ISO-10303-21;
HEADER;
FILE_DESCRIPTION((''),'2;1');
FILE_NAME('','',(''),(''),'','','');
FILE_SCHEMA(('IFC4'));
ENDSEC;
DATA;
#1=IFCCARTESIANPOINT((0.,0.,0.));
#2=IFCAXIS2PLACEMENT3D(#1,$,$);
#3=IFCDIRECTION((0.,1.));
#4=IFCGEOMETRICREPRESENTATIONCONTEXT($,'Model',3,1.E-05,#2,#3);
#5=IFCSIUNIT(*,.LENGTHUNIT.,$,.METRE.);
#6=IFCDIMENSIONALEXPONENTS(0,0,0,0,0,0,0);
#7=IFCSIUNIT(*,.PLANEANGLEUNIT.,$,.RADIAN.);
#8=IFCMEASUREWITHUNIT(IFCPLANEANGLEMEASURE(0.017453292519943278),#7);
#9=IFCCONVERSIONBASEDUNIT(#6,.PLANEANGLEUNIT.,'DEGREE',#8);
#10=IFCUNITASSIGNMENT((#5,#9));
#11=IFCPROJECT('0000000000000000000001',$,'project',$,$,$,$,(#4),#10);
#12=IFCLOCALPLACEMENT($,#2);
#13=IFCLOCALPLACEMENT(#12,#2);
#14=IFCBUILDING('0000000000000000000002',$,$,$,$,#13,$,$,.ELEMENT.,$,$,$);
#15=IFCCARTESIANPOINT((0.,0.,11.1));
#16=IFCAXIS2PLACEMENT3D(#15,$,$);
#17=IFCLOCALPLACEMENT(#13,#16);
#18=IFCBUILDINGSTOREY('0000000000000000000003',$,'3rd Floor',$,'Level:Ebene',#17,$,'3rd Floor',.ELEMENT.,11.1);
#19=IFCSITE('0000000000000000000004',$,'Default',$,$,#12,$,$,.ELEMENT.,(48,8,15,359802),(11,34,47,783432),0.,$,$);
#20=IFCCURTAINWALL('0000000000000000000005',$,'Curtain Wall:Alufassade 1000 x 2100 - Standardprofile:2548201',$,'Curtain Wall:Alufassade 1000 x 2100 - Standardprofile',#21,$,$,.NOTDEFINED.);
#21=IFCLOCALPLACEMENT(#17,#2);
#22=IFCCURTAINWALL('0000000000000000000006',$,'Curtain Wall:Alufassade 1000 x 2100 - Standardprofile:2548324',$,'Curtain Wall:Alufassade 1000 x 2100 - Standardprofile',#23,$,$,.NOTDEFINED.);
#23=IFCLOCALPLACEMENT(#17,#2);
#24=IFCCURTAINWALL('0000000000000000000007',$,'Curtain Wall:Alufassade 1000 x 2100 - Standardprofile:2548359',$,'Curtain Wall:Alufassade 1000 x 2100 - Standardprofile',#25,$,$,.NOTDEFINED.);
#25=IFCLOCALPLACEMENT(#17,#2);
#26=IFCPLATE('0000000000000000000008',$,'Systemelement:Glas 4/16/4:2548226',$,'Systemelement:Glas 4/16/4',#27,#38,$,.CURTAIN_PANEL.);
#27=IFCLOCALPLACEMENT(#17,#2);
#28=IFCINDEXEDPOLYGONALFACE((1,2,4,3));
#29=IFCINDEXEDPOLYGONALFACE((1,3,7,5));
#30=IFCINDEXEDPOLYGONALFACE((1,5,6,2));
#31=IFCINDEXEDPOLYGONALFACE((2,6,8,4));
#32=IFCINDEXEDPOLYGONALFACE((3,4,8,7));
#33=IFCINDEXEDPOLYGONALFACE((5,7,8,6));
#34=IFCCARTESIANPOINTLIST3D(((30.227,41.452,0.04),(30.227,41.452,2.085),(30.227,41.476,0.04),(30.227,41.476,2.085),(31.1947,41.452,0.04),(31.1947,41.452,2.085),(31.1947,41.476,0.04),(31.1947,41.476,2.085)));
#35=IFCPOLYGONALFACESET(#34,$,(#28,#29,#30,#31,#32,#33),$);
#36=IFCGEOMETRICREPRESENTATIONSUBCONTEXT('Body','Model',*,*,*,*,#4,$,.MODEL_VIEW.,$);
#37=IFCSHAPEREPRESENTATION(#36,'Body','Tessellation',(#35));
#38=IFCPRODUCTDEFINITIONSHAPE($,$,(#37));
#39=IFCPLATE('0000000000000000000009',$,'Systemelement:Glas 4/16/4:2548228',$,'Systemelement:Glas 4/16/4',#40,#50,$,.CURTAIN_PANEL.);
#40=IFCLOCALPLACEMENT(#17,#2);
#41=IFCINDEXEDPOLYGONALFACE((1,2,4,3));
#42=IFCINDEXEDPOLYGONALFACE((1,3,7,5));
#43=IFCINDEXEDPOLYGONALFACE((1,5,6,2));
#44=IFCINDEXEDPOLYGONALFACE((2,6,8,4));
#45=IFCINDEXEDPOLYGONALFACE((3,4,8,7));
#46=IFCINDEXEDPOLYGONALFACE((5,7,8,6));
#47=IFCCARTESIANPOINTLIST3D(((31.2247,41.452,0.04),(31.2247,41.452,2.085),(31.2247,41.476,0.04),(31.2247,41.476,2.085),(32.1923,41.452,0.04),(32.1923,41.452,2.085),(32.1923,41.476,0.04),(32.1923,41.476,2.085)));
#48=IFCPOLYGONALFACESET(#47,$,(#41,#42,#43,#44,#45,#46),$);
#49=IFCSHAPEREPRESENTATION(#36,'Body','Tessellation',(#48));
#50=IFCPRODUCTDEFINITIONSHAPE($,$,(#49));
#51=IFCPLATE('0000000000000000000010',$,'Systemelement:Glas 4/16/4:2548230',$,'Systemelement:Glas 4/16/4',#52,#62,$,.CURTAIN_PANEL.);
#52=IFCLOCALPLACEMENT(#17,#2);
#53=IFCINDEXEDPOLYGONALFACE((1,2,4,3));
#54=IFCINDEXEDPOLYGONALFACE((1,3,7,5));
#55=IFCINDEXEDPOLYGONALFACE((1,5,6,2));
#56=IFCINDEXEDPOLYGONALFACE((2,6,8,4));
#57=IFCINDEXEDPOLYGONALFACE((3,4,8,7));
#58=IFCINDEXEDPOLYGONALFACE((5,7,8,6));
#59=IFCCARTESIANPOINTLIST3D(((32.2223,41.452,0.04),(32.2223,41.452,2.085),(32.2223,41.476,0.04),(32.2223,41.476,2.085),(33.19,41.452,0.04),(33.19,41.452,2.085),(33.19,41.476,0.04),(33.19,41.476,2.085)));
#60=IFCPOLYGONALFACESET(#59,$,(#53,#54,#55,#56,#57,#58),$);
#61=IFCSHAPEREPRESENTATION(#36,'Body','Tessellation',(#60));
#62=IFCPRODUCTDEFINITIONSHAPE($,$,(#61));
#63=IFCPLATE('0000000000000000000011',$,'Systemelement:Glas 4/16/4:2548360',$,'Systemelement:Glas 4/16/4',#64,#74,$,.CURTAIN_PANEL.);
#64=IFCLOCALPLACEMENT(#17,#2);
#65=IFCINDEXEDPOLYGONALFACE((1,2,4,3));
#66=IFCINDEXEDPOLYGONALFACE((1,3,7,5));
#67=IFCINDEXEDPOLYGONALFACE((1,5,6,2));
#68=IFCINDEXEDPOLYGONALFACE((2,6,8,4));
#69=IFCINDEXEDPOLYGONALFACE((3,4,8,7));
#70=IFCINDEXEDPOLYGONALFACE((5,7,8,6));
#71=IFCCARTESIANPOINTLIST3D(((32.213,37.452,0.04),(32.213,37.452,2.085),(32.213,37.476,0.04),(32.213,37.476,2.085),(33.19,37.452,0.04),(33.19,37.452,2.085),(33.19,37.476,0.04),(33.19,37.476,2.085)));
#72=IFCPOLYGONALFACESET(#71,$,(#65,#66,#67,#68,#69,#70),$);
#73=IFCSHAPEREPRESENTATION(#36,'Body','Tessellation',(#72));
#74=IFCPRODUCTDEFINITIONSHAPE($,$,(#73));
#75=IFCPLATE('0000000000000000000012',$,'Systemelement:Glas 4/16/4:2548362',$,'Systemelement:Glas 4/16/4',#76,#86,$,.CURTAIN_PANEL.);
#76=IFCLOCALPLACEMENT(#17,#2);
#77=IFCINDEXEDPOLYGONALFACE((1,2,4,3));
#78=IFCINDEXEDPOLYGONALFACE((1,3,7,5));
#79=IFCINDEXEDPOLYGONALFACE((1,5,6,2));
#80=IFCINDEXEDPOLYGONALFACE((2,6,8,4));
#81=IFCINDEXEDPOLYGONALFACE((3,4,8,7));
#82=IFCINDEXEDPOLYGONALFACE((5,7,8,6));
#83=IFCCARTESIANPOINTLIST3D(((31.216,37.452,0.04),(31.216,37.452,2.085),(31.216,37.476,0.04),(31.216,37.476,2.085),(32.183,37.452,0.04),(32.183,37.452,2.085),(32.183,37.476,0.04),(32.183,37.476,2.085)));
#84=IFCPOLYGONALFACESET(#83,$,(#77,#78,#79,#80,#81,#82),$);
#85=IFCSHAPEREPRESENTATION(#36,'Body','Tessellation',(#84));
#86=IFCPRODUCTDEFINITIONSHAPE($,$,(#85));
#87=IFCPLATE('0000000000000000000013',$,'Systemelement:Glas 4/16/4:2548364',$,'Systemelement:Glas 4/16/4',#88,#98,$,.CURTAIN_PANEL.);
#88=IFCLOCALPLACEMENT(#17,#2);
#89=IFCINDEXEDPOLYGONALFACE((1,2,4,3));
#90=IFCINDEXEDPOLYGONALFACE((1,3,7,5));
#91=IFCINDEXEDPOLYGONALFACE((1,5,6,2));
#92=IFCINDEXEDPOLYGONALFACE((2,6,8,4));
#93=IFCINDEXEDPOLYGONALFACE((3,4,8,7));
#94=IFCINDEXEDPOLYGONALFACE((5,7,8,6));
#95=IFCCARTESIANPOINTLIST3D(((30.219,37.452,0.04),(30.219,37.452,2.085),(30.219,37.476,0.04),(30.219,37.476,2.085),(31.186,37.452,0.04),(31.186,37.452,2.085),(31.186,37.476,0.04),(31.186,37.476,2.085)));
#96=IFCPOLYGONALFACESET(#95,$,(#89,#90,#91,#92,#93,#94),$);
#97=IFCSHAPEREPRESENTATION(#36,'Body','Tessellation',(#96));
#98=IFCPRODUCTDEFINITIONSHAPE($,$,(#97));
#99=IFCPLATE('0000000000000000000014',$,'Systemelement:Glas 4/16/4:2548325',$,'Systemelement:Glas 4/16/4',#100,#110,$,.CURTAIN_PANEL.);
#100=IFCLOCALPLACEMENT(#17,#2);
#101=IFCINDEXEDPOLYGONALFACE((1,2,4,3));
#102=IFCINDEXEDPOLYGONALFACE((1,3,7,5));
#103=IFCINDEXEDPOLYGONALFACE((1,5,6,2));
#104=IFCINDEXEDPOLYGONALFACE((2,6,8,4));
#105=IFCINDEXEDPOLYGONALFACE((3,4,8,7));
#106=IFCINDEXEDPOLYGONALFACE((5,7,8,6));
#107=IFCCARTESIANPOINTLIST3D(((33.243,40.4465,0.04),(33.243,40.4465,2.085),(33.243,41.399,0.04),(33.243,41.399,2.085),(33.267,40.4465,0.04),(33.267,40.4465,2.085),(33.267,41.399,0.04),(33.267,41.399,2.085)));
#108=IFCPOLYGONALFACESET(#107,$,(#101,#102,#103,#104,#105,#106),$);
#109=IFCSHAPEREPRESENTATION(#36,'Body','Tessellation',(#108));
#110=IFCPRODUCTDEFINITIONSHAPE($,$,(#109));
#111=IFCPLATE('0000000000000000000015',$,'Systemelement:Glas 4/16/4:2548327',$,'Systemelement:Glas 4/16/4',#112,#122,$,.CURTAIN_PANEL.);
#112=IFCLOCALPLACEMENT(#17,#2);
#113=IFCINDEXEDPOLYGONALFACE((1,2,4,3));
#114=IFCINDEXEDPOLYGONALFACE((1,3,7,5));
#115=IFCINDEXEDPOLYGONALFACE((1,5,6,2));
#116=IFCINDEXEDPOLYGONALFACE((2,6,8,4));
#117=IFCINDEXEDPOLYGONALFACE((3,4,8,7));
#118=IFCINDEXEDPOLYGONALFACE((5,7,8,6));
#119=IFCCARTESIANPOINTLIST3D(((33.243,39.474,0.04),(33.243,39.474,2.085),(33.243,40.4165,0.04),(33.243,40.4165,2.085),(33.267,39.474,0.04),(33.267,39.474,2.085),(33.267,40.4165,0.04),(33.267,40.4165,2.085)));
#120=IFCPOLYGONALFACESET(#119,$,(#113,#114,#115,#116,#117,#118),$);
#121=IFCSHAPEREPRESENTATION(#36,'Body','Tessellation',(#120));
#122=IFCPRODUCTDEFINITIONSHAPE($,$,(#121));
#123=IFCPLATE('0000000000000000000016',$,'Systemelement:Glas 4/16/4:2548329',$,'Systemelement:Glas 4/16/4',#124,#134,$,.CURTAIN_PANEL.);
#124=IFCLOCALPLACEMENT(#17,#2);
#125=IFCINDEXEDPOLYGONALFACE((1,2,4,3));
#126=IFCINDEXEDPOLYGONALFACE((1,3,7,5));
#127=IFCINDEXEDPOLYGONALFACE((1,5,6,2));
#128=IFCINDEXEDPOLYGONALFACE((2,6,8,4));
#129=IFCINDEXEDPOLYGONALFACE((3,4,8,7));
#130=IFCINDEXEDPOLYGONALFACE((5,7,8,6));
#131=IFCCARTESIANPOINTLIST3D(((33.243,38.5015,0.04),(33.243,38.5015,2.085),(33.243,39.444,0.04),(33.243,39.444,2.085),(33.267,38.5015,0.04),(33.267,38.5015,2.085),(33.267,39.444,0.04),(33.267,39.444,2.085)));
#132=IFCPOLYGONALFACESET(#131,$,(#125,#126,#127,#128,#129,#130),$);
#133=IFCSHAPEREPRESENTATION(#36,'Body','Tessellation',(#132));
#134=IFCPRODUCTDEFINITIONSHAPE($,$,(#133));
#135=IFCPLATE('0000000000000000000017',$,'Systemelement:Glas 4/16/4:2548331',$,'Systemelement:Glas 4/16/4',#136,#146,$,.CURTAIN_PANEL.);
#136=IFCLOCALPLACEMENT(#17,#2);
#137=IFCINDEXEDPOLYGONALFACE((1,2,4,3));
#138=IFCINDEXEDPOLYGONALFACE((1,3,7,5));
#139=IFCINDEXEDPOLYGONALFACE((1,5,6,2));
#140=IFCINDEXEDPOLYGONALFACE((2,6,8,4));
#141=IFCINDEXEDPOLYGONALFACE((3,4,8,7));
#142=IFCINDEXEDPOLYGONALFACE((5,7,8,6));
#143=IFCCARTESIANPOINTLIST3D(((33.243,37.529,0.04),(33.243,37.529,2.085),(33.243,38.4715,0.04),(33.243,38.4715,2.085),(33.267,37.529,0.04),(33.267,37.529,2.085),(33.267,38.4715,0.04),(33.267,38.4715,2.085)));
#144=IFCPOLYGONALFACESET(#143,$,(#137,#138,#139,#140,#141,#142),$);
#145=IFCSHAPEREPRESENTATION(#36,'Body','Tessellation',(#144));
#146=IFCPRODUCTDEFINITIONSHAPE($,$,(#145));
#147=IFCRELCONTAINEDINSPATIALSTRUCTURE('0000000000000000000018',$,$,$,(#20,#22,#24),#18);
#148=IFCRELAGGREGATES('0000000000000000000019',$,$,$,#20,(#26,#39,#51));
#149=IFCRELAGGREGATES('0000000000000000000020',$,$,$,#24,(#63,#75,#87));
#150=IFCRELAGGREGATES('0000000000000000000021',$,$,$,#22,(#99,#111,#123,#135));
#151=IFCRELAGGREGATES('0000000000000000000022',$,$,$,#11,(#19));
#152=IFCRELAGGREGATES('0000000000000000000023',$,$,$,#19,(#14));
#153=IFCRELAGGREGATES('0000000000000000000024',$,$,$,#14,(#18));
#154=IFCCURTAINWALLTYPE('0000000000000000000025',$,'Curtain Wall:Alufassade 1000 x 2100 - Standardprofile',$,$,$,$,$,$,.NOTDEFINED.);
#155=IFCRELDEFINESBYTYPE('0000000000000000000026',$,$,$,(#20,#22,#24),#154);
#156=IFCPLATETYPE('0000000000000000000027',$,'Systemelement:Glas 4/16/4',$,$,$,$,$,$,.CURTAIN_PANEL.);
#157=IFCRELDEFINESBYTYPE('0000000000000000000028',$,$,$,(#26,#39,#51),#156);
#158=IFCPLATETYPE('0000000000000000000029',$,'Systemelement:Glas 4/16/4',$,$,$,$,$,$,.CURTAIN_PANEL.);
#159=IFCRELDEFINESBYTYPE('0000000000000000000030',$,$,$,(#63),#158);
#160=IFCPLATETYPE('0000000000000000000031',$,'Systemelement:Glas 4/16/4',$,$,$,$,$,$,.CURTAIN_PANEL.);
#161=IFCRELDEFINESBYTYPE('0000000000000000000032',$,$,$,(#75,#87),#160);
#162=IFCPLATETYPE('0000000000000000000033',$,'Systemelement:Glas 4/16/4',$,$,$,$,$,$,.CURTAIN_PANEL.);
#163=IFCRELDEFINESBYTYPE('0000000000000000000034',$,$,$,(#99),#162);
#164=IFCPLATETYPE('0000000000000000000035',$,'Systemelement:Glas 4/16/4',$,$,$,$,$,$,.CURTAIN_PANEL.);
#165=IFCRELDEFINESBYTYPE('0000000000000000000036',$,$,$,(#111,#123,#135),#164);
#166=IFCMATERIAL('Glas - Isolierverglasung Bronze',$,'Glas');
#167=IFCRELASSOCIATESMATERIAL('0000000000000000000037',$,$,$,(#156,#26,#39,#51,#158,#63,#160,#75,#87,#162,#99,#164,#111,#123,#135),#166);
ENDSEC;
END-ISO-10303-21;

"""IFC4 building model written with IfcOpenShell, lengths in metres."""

from ifc_helpers import new_model, entity, si_unit, converted_unit, direction, frame, origin, place, context, subcontext, project, spatial, indexed_curve, outline, extrude, source, transform, mapped, material, type_object, type_shapes, element, aggregate, save


model = new_model("IFC4")

# Units and contexts
model_context = context("Model", 3, precision=1e-05, world=origin(), true_north=direction((0.0, 1.0)))
body_context = subcontext(model_context, "Body", "Model", "MODEL_VIEW")
ifc_project = project(units=[si_unit("LENGTHUNIT", "METRE"), converted_unit("PLANEANGLEUNIT", "DEGREE", entity("IfcPlaneAngleMeasure", 0.017453292519943278), si_unit("PLANEANGLEUNIT", "RADIAN"), dimensions=[0, 0, 0, 0, 0, 0, 0])], contexts=[model_context])

# Site, building, storey
site_placement = place(None, origin())
site = spatial("IfcSite", under=ifc_project, at=site_placement, Name="Default", CompositionType="ELEMENT", RefLatitude=(48, 8, 15, 359802), RefLongitude=(11, 34, 47, 783432), RefElevation=0.0)
building_placement = place(site_placement, origin())
building = spatial("IfcBuilding", under=site, at=building_placement, CompositionType="ELEMENT")
storey_placement = place(building_placement, frame((0.0, 0.0, 11.1)))
storey = spatial("IfcBuildingStorey", under=building, at=storey_placement, Name="3rd Floor", ObjectType="Level:Ebene", LongName="3rd Floor", CompositionType="ELEMENT", Elevation=11.1)

# Curtain walls
curtain_wall_type = type_object("IfcCurtainWallType", Name="Curtain Wall:Alufassade 1000 x 2100 - Standardprofile", PredefinedType="NOTDEFINED")
curtain_wall_1_placement = place(storey_placement, frame((0.0, 0.0, -11.1)))
curtain_wall_1 = element("IfcCurtainWall", 1, at=curtain_wall_1_placement, inside=storey, type_object=curtain_wall_type, Name="Curtain Wall:Alufassade 1000 x 2100 - Standardprofile:2548201", ObjectType="Curtain Wall:Alufassade 1000 x 2100 - Standardprofile", PredefinedType="NOTDEFINED")
curtain_wall_2_placement = place(storey_placement, frame((0.0, 0.0, -11.1)))
curtain_wall_2 = element("IfcCurtainWall", 2, at=curtain_wall_2_placement, inside=storey, type_object=curtain_wall_type, Name="Curtain Wall:Alufassade 1000 x 2100 - Standardprofile:2548324", ObjectType="Curtain Wall:Alufassade 1000 x 2100 - Standardprofile", PredefinedType="NOTDEFINED")

# Curtain wall
curtain_wall_3_placement = place(storey_placement, frame((0.0, 0.0, -11.1)))
curtain_wall_3 = element("IfcCurtainWall", 3, at=curtain_wall_3_placement, inside=storey, type_object=curtain_wall_type, Name="Curtain Wall:Alufassade 1000 x 2100 - Standardprofile:2548359", ObjectType="Curtain Wall:Alufassade 1000 x 2100 - Standardprofile", PredefinedType="NOTDEFINED")

# Plates
ifc_material_1 = material(Name="Glas - Isolierverglasung Bronze", Category="Glas")
plate_type_1 = type_object("IfcPlateType", Name="Systemelement:Glas 4/16/4", PredefinedType="CURTAIN_PANEL", material=ifc_material_1)
shared_shape_1 = source(origin(), body_context, "Body", "SweptSolid", [
    extrude(outline(indexed_curve([(-0.012, -0.4838), (0.012, -0.4838), (0.012, 0.4838), (-0.012, 0.4838), (-0.012, -0.4838)], self_intersect=False)), frame((0.0, 0.0, 0.0), z_axis=(0.0, 0.0, 1.0), x_axis=(0.0, 1.0, 0.0)), (0.0, 0.0, 1.0), 2.045),
])
type_shapes(plate_type_1, [shared_shape_1])
plate_1_placement = place(curtain_wall_1_placement, frame((30.7108, 41.464, 11.14)))
plate_1 = element("IfcPlate", 4, at=plate_1_placement, type_object=plate_type_1, material=ifc_material_1, Name="Systemelement:Glas 4/16/4:2548226", ObjectType="Systemelement:Glas 4/16/4", PredefinedType="CURTAIN_PANEL", context=body_context, shape_type="MappedRepresentation", body=[
    mapped(shared_shape_1, transform((0.0, 0.0, 0.0), scale=1.0)),
])
plate_2_placement = place(curtain_wall_1_placement, frame((31.7085, 41.464, 11.14)))
plate_2 = element("IfcPlate", 5, at=plate_2_placement, type_object=plate_type_1, material=ifc_material_1, Name="Systemelement:Glas 4/16/4:2548228", ObjectType="Systemelement:Glas 4/16/4", PredefinedType="CURTAIN_PANEL", context=body_context, shape_type="MappedRepresentation", body=[
    mapped(shared_shape_1, transform((0.0, 0.0, 0.0), scale=1.0)),
])
plate_3_placement = place(curtain_wall_1_placement, frame((32.7062, 41.464, 11.14)))
plate_3 = element("IfcPlate", 6, at=plate_3_placement, type_object=plate_type_1, material=ifc_material_1, Name="Systemelement:Glas 4/16/4:2548230", ObjectType="Systemelement:Glas 4/16/4", PredefinedType="CURTAIN_PANEL", context=body_context, shape_type="MappedRepresentation", body=[
    mapped(shared_shape_1, transform((0.0, 0.0, 0.0), scale=1.0)),
])
aggregate(curtain_wall_1, [plate_1, plate_2, plate_3])
plate_type_2 = type_object("IfcPlateType", Name="Systemelement:Glas 4/16/4", PredefinedType="CURTAIN_PANEL", material=ifc_material_1)
shared_shape_2 = source(origin(), body_context, "Body", "SweptSolid", [
    extrude(outline(indexed_curve([(-0.012, -0.4885), (0.012, -0.4885), (0.012, 0.4885), (-0.012, 0.4885), (-0.012, -0.4885)], self_intersect=False)), frame((0.0, 0.0, 0.0), z_axis=(0.0, 0.0, 1.0), x_axis=(0.0, 1.0, 0.0)), (0.0, 0.0, 1.0), 2.045),
])
type_shapes(plate_type_2, [shared_shape_2])
plate_4_placement = place(curtain_wall_3_placement, frame((32.7015, 37.464, 11.14), z_axis=(0.0, 0.0, 1.0), x_axis=(-1.0, 0.0, 0.0)))
plate_4 = element("IfcPlate", 7, at=plate_4_placement, type_object=plate_type_2, material=ifc_material_1, Name="Systemelement:Glas 4/16/4:2548360", ObjectType="Systemelement:Glas 4/16/4", PredefinedType="CURTAIN_PANEL", context=body_context, shape_type="MappedRepresentation", body=[
    mapped(shared_shape_2, transform((0.0, 0.0, 0.0), scale=1.0)),
])
plate_type_3 = type_object("IfcPlateType", Name="Systemelement:Glas 4/16/4", PredefinedType="CURTAIN_PANEL", material=ifc_material_1)
shared_shape_3 = source(origin(), body_context, "Body", "SweptSolid", [
    extrude(outline(indexed_curve([(-0.012, -0.4835), (0.012, -0.4835), (0.012, 0.4835), (-0.012, 0.4835), (-0.012, -0.4835)], self_intersect=False)), frame((0.0, 0.0, 0.0), z_axis=(0.0, 0.0, 1.0), x_axis=(0.0, 1.0, 0.0)), (0.0, 0.0, 1.0), 2.045),
])
type_shapes(plate_type_3, [shared_shape_3])
plate_5_placement = place(curtain_wall_3_placement, frame((31.6995, 37.464, 11.14), z_axis=(0.0, 0.0, 1.0), x_axis=(-1.0, 0.0, 0.0)))
plate_5 = element("IfcPlate", 8, at=plate_5_placement, type_object=plate_type_3, material=ifc_material_1, Name="Systemelement:Glas 4/16/4:2548362", ObjectType="Systemelement:Glas 4/16/4", PredefinedType="CURTAIN_PANEL", context=body_context, shape_type="MappedRepresentation", body=[
    mapped(shared_shape_3, transform((0.0, 0.0, 0.0), scale=1.0)),
])
plate_6_placement = place(curtain_wall_3_placement, frame((30.7025, 37.464, 11.14), z_axis=(0.0, 0.0, 1.0), x_axis=(-1.0, 0.0, 0.0)))
plate_6 = element("IfcPlate", 9, at=plate_6_placement, type_object=plate_type_3, material=ifc_material_1, Name="Systemelement:Glas 4/16/4:2548364", ObjectType="Systemelement:Glas 4/16/4", PredefinedType="CURTAIN_PANEL", context=body_context, shape_type="MappedRepresentation", body=[
    mapped(shared_shape_3, transform((0.0, 0.0, 0.0), scale=1.0)),
])
aggregate(curtain_wall_3, [plate_4, plate_5, plate_6])
plate_type_4 = type_object("IfcPlateType", Name="Systemelement:Glas 4/16/4", PredefinedType="CURTAIN_PANEL", material=ifc_material_1)
shared_shape_4 = source(origin(), body_context, "Body", "SweptSolid", [
    extrude(outline(indexed_curve([(-0.012, -0.4763), (0.012, -0.4763), (0.012, 0.4763), (-0.012, 0.4763), (-0.012, -0.4763)], self_intersect=False)), frame((0.0, 0.0, 0.0), z_axis=(0.0, 0.0, 1.0), x_axis=(0.0, 1.0, 0.0)), (0.0, 0.0, 1.0), 2.045),
])
type_shapes(plate_type_4, [shared_shape_4])
plate_7_placement = place(curtain_wall_2_placement, frame((33.255, 40.9228, 11.14), z_axis=(0.0, 0.0, 1.0), x_axis=(0.0, -1.0, 0.0)))
plate_7 = element("IfcPlate", 10, at=plate_7_placement, type_object=plate_type_4, material=ifc_material_1, Name="Systemelement:Glas 4/16/4:2548325", ObjectType="Systemelement:Glas 4/16/4", PredefinedType="CURTAIN_PANEL", context=body_context, shape_type="MappedRepresentation", body=[
    mapped(shared_shape_4, transform((0.0, 0.0, 0.0), scale=1.0)),
])
plate_type_5 = type_object("IfcPlateType", Name="Systemelement:Glas 4/16/4", PredefinedType="CURTAIN_PANEL", material=ifc_material_1)
shared_shape_5 = source(origin(), body_context, "Body", "SweptSolid", [
    extrude(outline(indexed_curve([(-0.012, -0.4712), (0.012, -0.4712), (0.012, 0.4712), (-0.012, 0.4712), (-0.012, -0.4712)], self_intersect=False)), frame((0.0, 0.0, 0.0), z_axis=(0.0, 0.0, 1.0), x_axis=(0.0, 1.0, 0.0)), (0.0, 0.0, 1.0), 2.045),
])
type_shapes(plate_type_5, [shared_shape_5])
plate_8_placement = place(curtain_wall_2_placement, frame((33.255, 39.9453, 11.14), z_axis=(0.0, 0.0, 1.0), x_axis=(0.0, -1.0, 0.0)))
plate_8 = element("IfcPlate", 11, at=plate_8_placement, type_object=plate_type_5, material=ifc_material_1, Name="Systemelement:Glas 4/16/4:2548327", ObjectType="Systemelement:Glas 4/16/4", PredefinedType="CURTAIN_PANEL", context=body_context, shape_type="MappedRepresentation", body=[
    mapped(shared_shape_5, transform((0.0, 0.0, 0.0), scale=1.0)),
])
plate_9_placement = place(curtain_wall_2_placement, frame((33.255, 38.9728, 11.14), z_axis=(0.0, 0.0, 1.0), x_axis=(0.0, -1.0, 0.0)))
plate_9 = element("IfcPlate", 12, at=plate_9_placement, type_object=plate_type_5, material=ifc_material_1, Name="Systemelement:Glas 4/16/4:2548329", ObjectType="Systemelement:Glas 4/16/4", PredefinedType="CURTAIN_PANEL", context=body_context, shape_type="MappedRepresentation", body=[
    mapped(shared_shape_5, transform((0.0, 0.0, 0.0), scale=1.0)),
])
plate_10_placement = place(curtain_wall_2_placement, frame((33.255, 38.0003, 11.14), z_axis=(0.0, 0.0, 1.0), x_axis=(0.0, -1.0, 0.0)))
plate_10 = element("IfcPlate", 13, at=plate_10_placement, type_object=plate_type_5, material=ifc_material_1, Name="Systemelement:Glas 4/16/4:2548331", ObjectType="Systemelement:Glas 4/16/4", PredefinedType="CURTAIN_PANEL", context=body_context, shape_type="MappedRepresentation", body=[
    mapped(shared_shape_5, transform((0.0, 0.0, 0.0), scale=1.0)),
])
aggregate(curtain_wall_2, [plate_7, plate_8, plate_9, plate_10])

save(model, "model.ifc")
